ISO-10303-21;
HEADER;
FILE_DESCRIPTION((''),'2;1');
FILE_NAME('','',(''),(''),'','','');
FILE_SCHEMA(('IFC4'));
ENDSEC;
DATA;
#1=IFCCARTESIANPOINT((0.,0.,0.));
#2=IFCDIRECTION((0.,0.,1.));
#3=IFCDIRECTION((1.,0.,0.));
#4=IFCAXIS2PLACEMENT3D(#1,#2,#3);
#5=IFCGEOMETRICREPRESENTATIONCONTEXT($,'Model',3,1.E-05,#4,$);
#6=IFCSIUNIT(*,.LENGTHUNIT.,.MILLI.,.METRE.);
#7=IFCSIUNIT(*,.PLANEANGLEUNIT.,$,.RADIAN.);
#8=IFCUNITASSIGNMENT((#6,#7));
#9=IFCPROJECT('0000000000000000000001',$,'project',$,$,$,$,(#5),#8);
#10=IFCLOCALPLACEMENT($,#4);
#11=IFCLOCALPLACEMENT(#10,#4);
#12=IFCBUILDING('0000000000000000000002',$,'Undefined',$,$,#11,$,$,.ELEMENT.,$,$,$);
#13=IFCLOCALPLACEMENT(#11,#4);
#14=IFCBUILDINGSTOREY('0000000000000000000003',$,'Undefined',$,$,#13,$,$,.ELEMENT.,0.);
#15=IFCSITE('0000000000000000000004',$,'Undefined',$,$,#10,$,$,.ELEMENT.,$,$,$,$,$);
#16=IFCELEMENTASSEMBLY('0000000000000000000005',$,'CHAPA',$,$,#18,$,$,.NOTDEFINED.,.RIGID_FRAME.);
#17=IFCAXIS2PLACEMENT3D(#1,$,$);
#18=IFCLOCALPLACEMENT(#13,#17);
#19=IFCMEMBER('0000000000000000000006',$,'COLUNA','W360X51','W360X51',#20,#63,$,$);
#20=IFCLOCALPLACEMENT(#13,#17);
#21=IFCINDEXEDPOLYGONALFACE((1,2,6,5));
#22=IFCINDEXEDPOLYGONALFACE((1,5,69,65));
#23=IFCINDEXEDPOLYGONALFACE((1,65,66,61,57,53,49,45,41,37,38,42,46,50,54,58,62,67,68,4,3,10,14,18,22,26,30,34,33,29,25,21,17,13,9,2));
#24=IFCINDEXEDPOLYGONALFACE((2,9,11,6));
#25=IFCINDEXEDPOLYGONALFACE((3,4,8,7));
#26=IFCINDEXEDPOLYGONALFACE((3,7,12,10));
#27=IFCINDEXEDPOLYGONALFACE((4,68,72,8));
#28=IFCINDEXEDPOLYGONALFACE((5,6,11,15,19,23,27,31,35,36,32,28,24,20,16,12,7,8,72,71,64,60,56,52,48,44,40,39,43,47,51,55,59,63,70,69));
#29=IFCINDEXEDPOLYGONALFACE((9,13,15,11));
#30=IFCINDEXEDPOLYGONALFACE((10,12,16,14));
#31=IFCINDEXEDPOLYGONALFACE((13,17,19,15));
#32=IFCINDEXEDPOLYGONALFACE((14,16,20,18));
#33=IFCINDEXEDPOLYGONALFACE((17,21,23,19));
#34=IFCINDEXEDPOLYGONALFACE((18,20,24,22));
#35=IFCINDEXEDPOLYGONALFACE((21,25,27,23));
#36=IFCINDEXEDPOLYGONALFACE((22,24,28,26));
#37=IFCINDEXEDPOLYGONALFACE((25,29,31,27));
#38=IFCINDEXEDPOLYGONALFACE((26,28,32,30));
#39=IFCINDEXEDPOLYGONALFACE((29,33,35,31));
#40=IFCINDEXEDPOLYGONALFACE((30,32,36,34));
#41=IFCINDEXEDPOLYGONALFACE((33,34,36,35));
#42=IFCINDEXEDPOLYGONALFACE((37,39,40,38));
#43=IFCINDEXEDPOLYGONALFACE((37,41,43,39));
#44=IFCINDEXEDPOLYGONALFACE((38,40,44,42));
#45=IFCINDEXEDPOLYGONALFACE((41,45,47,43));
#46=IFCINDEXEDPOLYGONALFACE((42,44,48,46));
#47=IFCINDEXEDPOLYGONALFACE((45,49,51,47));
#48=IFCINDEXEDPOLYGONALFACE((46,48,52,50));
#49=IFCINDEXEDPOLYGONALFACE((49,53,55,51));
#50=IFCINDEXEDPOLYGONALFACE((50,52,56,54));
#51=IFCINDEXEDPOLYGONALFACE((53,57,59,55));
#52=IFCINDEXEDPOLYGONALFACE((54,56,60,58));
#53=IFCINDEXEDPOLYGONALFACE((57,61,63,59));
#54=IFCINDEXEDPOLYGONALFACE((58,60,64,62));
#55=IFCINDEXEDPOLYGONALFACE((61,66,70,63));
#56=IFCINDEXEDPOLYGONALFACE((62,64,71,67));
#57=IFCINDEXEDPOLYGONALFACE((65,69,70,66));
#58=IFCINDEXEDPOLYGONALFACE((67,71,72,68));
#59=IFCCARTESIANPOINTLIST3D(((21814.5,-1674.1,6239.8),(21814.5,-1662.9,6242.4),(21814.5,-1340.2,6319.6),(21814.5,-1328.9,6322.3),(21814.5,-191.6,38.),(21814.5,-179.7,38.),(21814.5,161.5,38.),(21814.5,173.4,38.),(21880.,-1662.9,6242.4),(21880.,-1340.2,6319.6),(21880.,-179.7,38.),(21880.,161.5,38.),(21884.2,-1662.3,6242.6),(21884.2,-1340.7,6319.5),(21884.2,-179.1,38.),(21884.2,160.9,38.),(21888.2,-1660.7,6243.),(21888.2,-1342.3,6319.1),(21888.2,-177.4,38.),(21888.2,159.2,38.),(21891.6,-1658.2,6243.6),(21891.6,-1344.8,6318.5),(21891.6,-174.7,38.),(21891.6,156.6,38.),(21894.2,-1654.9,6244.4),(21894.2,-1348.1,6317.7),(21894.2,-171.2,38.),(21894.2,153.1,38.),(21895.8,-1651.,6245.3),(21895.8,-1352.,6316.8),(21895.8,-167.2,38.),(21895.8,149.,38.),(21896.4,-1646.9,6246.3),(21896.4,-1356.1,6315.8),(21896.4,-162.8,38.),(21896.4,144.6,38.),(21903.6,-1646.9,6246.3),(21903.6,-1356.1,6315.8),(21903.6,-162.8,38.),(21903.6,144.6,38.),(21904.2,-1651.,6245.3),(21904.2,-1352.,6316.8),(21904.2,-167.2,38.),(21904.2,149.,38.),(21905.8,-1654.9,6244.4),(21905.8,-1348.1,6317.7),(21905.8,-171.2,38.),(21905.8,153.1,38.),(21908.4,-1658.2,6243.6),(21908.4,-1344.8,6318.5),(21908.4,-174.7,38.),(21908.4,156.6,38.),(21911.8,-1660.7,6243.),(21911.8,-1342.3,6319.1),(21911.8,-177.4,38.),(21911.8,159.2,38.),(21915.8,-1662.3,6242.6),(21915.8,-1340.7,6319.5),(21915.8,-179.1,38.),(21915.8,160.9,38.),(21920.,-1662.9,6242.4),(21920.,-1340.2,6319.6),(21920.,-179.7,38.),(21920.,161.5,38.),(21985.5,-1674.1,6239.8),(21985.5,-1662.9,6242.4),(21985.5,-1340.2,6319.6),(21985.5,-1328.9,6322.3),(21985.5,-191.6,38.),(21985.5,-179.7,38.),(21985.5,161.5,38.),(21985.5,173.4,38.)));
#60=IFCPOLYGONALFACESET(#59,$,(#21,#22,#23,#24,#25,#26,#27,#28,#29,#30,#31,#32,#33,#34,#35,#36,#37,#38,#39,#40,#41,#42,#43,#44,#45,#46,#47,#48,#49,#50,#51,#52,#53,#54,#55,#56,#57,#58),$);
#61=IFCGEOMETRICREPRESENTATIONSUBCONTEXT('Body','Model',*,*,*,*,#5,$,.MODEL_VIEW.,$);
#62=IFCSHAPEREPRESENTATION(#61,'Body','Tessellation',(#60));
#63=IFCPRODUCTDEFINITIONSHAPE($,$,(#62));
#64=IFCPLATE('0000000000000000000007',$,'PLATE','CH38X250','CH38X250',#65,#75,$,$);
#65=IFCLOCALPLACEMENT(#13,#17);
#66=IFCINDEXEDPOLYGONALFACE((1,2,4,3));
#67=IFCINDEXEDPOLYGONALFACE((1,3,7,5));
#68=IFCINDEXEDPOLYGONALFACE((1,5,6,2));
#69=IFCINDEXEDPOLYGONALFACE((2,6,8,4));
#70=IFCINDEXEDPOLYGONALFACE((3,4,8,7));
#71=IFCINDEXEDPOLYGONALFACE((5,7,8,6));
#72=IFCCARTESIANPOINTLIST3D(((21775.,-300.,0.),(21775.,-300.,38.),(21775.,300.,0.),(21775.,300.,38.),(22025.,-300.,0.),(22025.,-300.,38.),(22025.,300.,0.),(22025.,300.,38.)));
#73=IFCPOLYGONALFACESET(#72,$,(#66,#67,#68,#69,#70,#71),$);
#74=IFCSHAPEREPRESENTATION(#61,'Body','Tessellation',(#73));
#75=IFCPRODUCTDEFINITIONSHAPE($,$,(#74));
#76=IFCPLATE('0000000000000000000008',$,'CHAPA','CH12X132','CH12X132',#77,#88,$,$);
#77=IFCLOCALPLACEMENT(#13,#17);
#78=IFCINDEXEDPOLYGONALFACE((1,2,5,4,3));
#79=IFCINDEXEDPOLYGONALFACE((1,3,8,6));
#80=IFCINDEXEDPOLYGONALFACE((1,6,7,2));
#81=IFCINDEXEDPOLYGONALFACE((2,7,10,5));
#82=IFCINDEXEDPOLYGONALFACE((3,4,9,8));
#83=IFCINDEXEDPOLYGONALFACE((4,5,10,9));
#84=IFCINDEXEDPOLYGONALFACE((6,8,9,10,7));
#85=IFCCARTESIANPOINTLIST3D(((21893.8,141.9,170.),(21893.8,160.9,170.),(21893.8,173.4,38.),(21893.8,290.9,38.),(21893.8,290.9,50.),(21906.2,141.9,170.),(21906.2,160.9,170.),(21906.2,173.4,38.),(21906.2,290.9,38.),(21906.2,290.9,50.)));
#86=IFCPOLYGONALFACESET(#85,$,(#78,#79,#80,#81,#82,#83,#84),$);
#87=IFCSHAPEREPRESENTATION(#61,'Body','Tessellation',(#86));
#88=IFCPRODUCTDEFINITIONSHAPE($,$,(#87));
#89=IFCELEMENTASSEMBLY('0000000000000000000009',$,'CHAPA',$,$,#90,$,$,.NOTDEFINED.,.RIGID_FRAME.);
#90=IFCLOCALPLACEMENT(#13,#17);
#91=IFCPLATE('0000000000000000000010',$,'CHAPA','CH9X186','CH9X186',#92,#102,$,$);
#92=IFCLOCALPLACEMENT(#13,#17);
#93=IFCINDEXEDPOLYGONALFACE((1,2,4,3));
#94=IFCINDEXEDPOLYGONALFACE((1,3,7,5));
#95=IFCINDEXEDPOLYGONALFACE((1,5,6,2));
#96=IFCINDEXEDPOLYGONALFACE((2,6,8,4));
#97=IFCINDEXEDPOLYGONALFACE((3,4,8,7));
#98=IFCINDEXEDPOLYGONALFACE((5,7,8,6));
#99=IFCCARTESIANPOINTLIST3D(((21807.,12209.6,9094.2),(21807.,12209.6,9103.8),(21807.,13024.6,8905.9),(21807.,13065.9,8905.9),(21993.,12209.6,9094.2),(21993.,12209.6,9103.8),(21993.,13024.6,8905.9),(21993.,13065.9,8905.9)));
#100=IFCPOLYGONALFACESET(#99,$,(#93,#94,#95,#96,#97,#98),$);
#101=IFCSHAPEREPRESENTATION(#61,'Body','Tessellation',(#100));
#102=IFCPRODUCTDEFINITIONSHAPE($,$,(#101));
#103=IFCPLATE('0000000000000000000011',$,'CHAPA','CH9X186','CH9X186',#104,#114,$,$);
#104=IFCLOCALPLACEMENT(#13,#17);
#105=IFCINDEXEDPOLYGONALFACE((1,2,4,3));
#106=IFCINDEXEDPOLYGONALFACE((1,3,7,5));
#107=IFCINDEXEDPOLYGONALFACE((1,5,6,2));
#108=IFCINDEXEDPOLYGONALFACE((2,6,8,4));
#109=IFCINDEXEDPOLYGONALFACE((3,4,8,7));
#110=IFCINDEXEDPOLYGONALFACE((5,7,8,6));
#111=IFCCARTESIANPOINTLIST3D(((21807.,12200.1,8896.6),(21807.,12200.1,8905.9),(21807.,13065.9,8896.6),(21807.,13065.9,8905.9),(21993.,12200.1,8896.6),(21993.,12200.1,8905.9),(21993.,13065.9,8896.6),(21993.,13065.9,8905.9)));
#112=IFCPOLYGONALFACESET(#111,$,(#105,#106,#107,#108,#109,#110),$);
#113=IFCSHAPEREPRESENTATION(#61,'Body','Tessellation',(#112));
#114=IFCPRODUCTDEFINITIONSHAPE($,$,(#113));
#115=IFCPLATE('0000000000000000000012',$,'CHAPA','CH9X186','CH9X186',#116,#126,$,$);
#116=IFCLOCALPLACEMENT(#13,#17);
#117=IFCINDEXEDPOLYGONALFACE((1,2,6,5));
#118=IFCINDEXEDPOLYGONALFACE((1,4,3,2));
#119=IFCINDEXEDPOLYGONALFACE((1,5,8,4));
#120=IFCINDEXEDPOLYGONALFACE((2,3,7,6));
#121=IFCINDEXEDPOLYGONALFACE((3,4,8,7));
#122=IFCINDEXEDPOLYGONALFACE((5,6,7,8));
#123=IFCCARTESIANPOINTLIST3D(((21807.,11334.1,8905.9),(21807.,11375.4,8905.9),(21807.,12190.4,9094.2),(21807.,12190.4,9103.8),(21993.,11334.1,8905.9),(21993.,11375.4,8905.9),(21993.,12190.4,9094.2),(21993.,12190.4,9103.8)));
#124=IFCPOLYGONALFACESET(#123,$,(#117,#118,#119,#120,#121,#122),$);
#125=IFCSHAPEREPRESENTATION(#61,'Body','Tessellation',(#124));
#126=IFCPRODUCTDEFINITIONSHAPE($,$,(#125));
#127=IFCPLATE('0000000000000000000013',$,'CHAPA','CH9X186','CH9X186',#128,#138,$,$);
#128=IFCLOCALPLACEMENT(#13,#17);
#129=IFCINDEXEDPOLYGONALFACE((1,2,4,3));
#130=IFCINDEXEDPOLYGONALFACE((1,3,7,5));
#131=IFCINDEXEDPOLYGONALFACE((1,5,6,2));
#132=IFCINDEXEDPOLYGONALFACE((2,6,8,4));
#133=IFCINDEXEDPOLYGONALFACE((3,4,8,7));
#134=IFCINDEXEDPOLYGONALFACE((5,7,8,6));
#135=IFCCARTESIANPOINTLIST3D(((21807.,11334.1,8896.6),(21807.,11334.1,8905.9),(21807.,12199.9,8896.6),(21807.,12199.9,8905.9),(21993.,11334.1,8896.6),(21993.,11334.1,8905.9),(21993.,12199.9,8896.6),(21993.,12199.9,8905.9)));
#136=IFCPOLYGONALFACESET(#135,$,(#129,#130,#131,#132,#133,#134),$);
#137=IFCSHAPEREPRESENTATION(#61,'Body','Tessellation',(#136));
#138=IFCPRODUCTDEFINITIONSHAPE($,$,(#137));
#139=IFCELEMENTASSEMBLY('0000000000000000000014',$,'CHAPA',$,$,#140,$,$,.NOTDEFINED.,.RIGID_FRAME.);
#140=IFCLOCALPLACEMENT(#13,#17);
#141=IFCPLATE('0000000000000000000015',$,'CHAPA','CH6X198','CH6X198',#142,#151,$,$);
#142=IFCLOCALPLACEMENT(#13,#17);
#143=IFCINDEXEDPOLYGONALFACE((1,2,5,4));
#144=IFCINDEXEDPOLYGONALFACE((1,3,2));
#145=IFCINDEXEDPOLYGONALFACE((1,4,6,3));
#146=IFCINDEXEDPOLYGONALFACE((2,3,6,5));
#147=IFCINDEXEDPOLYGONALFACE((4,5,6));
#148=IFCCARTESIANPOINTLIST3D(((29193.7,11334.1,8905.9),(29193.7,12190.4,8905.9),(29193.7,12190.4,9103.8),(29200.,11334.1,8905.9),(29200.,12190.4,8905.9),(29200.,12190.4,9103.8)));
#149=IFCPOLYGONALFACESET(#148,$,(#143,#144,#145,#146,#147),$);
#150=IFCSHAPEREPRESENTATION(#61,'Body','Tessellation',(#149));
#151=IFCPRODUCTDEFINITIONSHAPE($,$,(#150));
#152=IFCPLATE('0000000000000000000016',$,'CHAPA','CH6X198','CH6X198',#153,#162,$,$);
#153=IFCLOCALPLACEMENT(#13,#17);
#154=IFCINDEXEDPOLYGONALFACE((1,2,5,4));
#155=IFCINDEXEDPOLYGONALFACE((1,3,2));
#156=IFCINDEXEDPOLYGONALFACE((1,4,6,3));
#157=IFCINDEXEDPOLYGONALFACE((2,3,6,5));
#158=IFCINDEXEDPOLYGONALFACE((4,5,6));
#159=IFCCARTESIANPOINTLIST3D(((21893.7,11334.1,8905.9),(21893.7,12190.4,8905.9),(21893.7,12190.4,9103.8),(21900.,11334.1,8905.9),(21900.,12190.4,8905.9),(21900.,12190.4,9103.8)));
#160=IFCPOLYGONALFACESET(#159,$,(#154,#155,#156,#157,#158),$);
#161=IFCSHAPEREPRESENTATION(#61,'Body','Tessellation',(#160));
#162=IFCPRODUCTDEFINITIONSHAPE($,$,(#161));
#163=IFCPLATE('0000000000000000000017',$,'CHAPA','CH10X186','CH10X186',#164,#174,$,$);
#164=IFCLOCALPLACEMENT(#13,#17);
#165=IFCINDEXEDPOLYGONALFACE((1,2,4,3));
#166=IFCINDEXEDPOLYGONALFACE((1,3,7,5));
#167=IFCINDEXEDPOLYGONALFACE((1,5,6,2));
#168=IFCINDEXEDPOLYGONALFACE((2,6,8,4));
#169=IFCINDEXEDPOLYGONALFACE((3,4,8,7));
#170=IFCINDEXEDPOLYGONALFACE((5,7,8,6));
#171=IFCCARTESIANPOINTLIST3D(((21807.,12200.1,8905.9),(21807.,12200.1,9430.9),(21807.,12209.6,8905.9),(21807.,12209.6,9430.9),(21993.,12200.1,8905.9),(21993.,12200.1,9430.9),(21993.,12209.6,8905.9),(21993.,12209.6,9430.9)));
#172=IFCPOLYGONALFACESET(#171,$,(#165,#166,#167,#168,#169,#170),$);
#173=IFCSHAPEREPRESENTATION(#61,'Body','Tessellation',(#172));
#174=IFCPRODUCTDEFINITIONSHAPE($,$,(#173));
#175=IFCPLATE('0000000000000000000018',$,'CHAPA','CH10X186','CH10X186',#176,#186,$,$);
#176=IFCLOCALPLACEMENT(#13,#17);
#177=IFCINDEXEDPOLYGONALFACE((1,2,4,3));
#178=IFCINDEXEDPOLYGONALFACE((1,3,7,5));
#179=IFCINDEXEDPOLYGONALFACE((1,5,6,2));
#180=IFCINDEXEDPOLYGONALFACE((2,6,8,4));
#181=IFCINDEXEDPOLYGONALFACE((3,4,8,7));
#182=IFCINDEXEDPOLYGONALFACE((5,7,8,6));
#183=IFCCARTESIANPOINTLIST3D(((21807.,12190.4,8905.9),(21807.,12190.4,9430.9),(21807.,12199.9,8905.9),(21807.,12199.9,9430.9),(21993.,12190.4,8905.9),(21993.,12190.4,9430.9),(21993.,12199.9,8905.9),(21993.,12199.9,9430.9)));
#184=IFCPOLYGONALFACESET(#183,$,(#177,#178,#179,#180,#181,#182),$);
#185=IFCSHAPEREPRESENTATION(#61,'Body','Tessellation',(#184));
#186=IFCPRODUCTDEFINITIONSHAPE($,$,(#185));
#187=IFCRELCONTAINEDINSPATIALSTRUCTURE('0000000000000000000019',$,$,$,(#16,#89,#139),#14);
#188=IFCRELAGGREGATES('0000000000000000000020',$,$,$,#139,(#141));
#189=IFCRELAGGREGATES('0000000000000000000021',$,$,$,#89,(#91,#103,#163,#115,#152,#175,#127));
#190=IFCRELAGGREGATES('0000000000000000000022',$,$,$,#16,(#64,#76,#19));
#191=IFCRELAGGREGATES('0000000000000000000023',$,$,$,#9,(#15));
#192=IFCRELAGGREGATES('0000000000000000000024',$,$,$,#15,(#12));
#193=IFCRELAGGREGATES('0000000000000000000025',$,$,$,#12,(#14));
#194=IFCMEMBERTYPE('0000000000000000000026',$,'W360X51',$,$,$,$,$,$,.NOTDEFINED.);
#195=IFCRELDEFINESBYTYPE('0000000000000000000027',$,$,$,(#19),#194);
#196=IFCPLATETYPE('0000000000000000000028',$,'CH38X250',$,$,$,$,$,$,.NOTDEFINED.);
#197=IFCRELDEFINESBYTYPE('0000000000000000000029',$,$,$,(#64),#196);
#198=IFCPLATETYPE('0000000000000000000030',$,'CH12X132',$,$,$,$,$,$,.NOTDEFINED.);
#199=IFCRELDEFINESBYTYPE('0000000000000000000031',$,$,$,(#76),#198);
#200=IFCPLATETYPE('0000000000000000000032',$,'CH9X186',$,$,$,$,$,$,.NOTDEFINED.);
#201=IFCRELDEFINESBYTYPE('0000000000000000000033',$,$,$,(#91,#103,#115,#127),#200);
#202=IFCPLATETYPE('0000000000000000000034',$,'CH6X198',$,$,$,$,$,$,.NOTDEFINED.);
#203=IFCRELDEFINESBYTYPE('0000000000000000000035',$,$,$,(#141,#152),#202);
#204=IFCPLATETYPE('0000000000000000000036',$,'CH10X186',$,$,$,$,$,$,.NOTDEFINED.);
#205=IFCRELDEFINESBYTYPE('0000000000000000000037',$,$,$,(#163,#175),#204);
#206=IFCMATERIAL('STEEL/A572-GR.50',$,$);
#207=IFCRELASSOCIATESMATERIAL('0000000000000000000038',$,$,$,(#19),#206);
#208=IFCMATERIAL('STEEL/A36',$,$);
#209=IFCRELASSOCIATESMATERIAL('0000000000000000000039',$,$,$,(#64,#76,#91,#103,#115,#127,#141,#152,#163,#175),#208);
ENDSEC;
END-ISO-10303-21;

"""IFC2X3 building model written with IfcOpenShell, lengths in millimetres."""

from ifc_helpers import new_model, si_unit, frame, origin_with_axes, origin_2d_with_axis, place, context, subcontext, project, spatial, polyline, i_section, outline, extrude, clip, halfspace, material, type_object, element, aggregate, save


model = new_model("IFC2X3")

# Units and contexts
model_context = context("Model", 3, precision=1e-05, world=origin_with_axes())
body_context = subcontext(model_context, "Body", "Model", "MODEL_VIEW")
ifc_project = project(units=[si_unit("LENGTHUNIT", "METRE", prefix="MILLI"), si_unit("PLANEANGLEUNIT", "RADIAN")], contexts=[model_context])

# Site, building, storey
site_placement = place(None, origin_with_axes())
site = spatial("IfcSite", under=ifc_project, at=site_placement, Name="Undefined", CompositionType="ELEMENT")
building_placement = place(site_placement, origin_with_axes())
building = spatial("IfcBuilding", under=site, at=building_placement, Name="Undefined", CompositionType="ELEMENT")
storey_placement = place(building_placement, origin_with_axes())
storey = spatial("IfcBuildingStorey", under=building, at=storey_placement, Name="Undefined", CompositionType="ELEMENT", Elevation=0.0)

# Element assembly, member, plates
assembly_1_placement = place(storey_placement, origin_with_axes())
assembly_1 = element("IfcElementAssembly", 1, at=assembly_1_placement, inside=storey, Name="CHAPA", AssemblyPlace="NOTDEFINED", PredefinedType="RIGID_FRAME")
ifc_material_1 = material(Name="STEEL/A572-GR.50")
member_type = type_object("IfcMemberType", Name="W360X51", PredefinedType="NOTDEFINED")
member_placement = place(assembly_1_placement, frame((21900.0, 23.3, -97.3), z_axis=(0.0, -0.972595, -0.232504), x_axis=(0.0, -0.232504, 0.972595)))
member = element("IfcMember", 2, at=member_placement, type_object=member_type, material=ifc_material_1, Name="COLUNA", Description="W360X51", ObjectType="W360X51", context=body_context, shape_type="Clipping", body=[
    clip(clip(extrude(i_section(OverallWidth=171.0, OverallDepth=355.0, WebThickness=7.2, FlangeThickness=11.6, FilletRadius=16.4, at=origin_2d_with_axis()), frame((6558.0, 0.0, 0.0), z_axis=(-1.0, 0.0, 0.0), x_axis=(0.0, -1.0, 0.0)), (0.0, 0.0, 1.0), 6542.9), halfspace(frame((94.5, 85.5, -186.3), z_axis=(-0.972595, 0.0, 0.232504), x_axis=(0.232504, 0.0, 0.972595)), False)), halfspace(frame((96.6, 0.0, -177.5), z_axis=(0.972595, 0.0, -0.232504), x_axis=(0.0, -1.0, 0.0)), True)),
])
ifc_material_2 = material(Name="STEEL/A36")
plate_type_1 = type_object("IfcPlateType", Name="CH38X250", PredefinedType="NOTDEFINED")
plate_1_placement = place(assembly_1_placement, frame((22025.0, -300.0, 19.0), z_axis=(0.0, 0.0, 1.0), x_axis=(0.0, 1.0, 0.0)))
plate_1 = element("IfcPlate", 3, at=plate_1_placement, type_object=plate_type_1, material=ifc_material_2, Name="PLATE", Description="CH38X250", ObjectType="CH38X250", context=body_context, shape_type="SweptSolid", body=[
    extrude(outline(polyline([(0.0, 0.0), (600.0, 0.0), (600.0, 250.0), (0.0, 250.0), (0.0, 0.0)])), frame((0.0, 0.0, -19.0), z_axis=(0.0, 0.0, 1.0), x_axis=(1.0, 0.0, 0.0)), (0.0, 0.0, 1.0), 38.0),
])
plate_type_2 = type_object("IfcPlateType", Name="CH12X132", PredefinedType="NOTDEFINED")
plate_2_placement = place(assembly_1_placement, frame((21900.0, 173.4, 38.0), z_axis=(1.0, 0.0, 0.0), x_axis=(0.0, 1.0, 0.0)))
plate_2 = element("IfcPlate", 4, at=plate_2_placement, type_object=plate_type_2, material=ifc_material_2, Name="CHAPA", Description="CH12X132", ObjectType="CH12X132", context=body_context, shape_type="SweptSolid", body=[
    extrude(outline(polyline([(0.0, 0.0), (117.5, 0.0), (117.5, 12.0), (-12.5, 132.0), (-31.6, 132.0), (0.0, 0.0)])), frame((0.0, 0.0, -6.2), z_axis=(0.0, 0.0, 1.0), x_axis=(1.0, 0.0, 0.0)), (0.0, 0.0, 1.0), 12.5),
])

# Element assembly, plates
assembly_2_placement = place(storey_placement, origin_with_axes())
assembly_2 = element("IfcElementAssembly", 5, at=assembly_2_placement, inside=storey, Name="CHAPA", AssemblyPlace="NOTDEFINED", PredefinedType="RIGID_FRAME")
plate_type_3 = type_object("IfcPlateType", Name="CH9X186", PredefinedType="NOTDEFINED")
plate_3_placement = place(assembly_2_placement, frame((21993.0, 12208.6, 9099.3), z_axis=(0.0, -0.225125, -0.97433), x_axis=(-1.0, 0.0, 0.0)))
plate_3 = element("IfcPlate", 6, at=plate_3_placement, type_object=plate_type_3, material=ifc_material_2, Name="CHAPA", Description="CH9X186", ObjectType="CH9X186", context=body_context, shape_type="Clipping", body=[
    clip(clip(extrude(outline(polyline([(0.0, 0.0), (186.0, 0.0), (186.0, 878.9), (0.0, 878.9), (0.0, 0.0)])), frame((0.0, 0.0, -4.7), z_axis=(0.0, 0.0, 1.0), x_axis=(1.0, 0.0, 0.0)), (0.0, 0.0, 1.0), 9.3), halfspace(frame((186.0, -500.0, 314.0), z_axis=(0.0, 0.225128, 0.974329), x_axis=(-1.0, 0.0, 0.0)), False)), halfspace(frame((0.0, 2.1, 4.7), z_axis=(0.0, -0.97433, 0.225125), x_axis=(1.0, 0.0, 0.0)), False)),
])
plate_4_placement = place(assembly_2_placement, frame((21993.0, 12200.1, 8901.3), z_axis=(0.0, 0.0, -1.0), x_axis=(-1.0, 0.0, 0.0)))
plate_4 = element("IfcPlate", 7, at=plate_4_placement, type_object=plate_type_3, material=ifc_material_2, Name="CHAPA", Description="CH9X186", ObjectType="CH9X186", context=body_context, shape_type="SweptSolid", body=[
    extrude(outline(polyline([(0.0, 0.0), (186.0, 0.0), (186.0, 865.8), (0.0, 865.8), (0.0, 0.0)])), frame((0.0, 0.0, -4.7), z_axis=(0.0, 0.0, 1.0), x_axis=(1.0, 0.0, 0.0)), (0.0, 0.0, 1.0), 9.3),
])
plate_5_placement = place(assembly_2_placement, frame((21993.0, 12191.4, 9099.3), z_axis=(0.0, -0.225125, 0.97433), x_axis=(-1.0, 0.0, 0.0)))
plate_5 = element("IfcPlate", 8, at=plate_5_placement, type_object=plate_type_3, material=ifc_material_2, Name="CHAPA", Description="CH9X186", ObjectType="CH9X186", context=body_context, shape_type="Clipping", body=[
    clip(clip(extrude(outline(polyline([(0.0, 0.0), (186.0, 0.0), (186.0, 878.9), (0.0, 878.9), (0.0, 0.0)])), frame((0.0, 0.0, -4.7), z_axis=(0.0, 0.0, 1.0), x_axis=(1.0, 0.0, 0.0)), (0.0, 0.0, 1.0), 9.3), halfspace(frame((186.0, -500.0, -314.0), z_axis=(0.0, 0.225128, -0.974329), x_axis=(0.0, 0.974329, 0.225128)), False)), halfspace(frame((0.0, 2.1, -4.6), z_axis=(0.0, -0.97433, -0.225125), x_axis=(0.0, -0.225125, 0.97433)), False)),
])
plate_6_placement = place(assembly_2_placement, frame((21993.0, 12199.9, 8901.3), z_axis=(0.0, 0.0, 1.0), x_axis=(-1.0, 0.0, 0.0)))
plate_6 = element("IfcPlate", 9, at=plate_6_placement, type_object=plate_type_3, material=ifc_material_2, Name="CHAPA", Description="CH9X186", ObjectType="CH9X186", context=body_context, shape_type="SweptSolid", body=[
    extrude(outline(polyline([(0.0, 0.0), (186.0, 0.0), (186.0, 865.8), (0.0, 865.8), (0.0, 0.0)])), frame((0.0, 0.0, -4.7), z_axis=(0.0, 0.0, 1.0), x_axis=(1.0, 0.0, 0.0)), (0.0, 0.0, 1.0), 9.3),
])

# Element assembly, plate
assembly_3_placement = place(storey_placement, origin_with_axes())
assembly_3 = element("IfcElementAssembly", 10, at=assembly_3_placement, inside=storey, Name="CHAPA", AssemblyPlace="NOTDEFINED", PredefinedType="RIGID_FRAME")
plate_type_4 = type_object("IfcPlateType", Name="CH6X198", PredefinedType="NOTDEFINED")
plate_7_placement = place(assembly_3_placement, frame((29196.8, 11334.1, 8905.9), z_axis=(1.0, 0.0, 0.0), x_axis=(0.0, 1.0, 0.0)))
plate_7 = element("IfcPlate", 11, at=plate_7_placement, type_object=plate_type_4, material=ifc_material_2, Name="CHAPA", Description="CH6X198", ObjectType="CH6X198", context=body_context, shape_type="SweptSolid", body=[
    extrude(outline(polyline([(0.0, 0.0), (856.3, 0.0), (856.3, 197.9), (0.0, 0.0)])), frame((0.0, 0.0, -3.1), z_axis=(0.0, 0.0, 1.0), x_axis=(1.0, 0.0, 0.0)), (0.0, 0.0, 1.0), 6.3),
])
aggregate(assembly_3, [plate_7])

# Plates
plate_8_placement = place(assembly_2_placement, frame((21896.8, 11334.1, 8905.9), z_axis=(1.0, 0.0, 0.0), x_axis=(0.0, 1.0, 0.0)))
plate_8 = element("IfcPlate", 12, at=plate_8_placement, type_object=plate_type_4, material=ifc_material_2, Name="CHAPA", Description="CH6X198", ObjectType="CH6X198", context=body_context, shape_type="SweptSolid", body=[
    extrude(outline(polyline([(0.0, 0.0), (856.3, 0.0), (856.3, 197.9), (0.0, 0.0)])), frame((0.0, 0.0, -3.1), z_axis=(0.0, 0.0, 1.0), x_axis=(1.0, 0.0, 0.0)), (0.0, 0.0, 1.0), 6.3),
])
plate_type_5 = type_object("IfcPlateType", Name="CH10X186", PredefinedType="NOTDEFINED")
plate_9_placement = place(assembly_2_placement, frame((21993.0, 12204.8, 9430.9), z_axis=(0.0, -1.0, 0.0), x_axis=(-1.0, 0.0, 0.0)))
plate_9 = element("IfcPlate", 13, at=plate_9_placement, type_object=plate_type_5, material=ifc_material_2, Name="CHAPA", Description="CH10X186", ObjectType="CH10X186", context=body_context, shape_type="SweptSolid", body=[
    extrude(outline(polyline([(0.0, 0.0), (186.0, 0.0), (186.0, 525.0), (0.0, 525.0), (0.0, 0.0)])), frame((0.0, 0.0, -4.8), z_axis=(0.0, 0.0, 1.0), x_axis=(1.0, 0.0, 0.0)), (0.0, 0.0, 1.0), 9.5),
])
plate_10_placement = place(assembly_2_placement, frame((21993.0, 12195.2, 9430.9), z_axis=(0.0, -1.0, 0.0), x_axis=(-1.0, 0.0, 0.0)))
plate_10 = element("IfcPlate", 14, at=plate_10_placement, type_object=plate_type_5, material=ifc_material_2, Name="CHAPA", Description="CH10X186", ObjectType="CH10X186", context=body_context, shape_type="SweptSolid", body=[
    extrude(outline(polyline([(0.0, 0.0), (186.0, 0.0), (186.0, 525.0), (0.0, 525.0), (0.0, 0.0)])), frame((0.0, 0.0, -4.8), z_axis=(0.0, 0.0, 1.0), x_axis=(1.0, 0.0, 0.0)), (0.0, 0.0, 1.0), 9.5),
])
aggregate(assembly_2, [plate_3, plate_4, plate_9, plate_5, plate_8, plate_10, plate_6])

aggregate(assembly_1, [plate_1, plate_2, member])

save(model, "model.ifc")
